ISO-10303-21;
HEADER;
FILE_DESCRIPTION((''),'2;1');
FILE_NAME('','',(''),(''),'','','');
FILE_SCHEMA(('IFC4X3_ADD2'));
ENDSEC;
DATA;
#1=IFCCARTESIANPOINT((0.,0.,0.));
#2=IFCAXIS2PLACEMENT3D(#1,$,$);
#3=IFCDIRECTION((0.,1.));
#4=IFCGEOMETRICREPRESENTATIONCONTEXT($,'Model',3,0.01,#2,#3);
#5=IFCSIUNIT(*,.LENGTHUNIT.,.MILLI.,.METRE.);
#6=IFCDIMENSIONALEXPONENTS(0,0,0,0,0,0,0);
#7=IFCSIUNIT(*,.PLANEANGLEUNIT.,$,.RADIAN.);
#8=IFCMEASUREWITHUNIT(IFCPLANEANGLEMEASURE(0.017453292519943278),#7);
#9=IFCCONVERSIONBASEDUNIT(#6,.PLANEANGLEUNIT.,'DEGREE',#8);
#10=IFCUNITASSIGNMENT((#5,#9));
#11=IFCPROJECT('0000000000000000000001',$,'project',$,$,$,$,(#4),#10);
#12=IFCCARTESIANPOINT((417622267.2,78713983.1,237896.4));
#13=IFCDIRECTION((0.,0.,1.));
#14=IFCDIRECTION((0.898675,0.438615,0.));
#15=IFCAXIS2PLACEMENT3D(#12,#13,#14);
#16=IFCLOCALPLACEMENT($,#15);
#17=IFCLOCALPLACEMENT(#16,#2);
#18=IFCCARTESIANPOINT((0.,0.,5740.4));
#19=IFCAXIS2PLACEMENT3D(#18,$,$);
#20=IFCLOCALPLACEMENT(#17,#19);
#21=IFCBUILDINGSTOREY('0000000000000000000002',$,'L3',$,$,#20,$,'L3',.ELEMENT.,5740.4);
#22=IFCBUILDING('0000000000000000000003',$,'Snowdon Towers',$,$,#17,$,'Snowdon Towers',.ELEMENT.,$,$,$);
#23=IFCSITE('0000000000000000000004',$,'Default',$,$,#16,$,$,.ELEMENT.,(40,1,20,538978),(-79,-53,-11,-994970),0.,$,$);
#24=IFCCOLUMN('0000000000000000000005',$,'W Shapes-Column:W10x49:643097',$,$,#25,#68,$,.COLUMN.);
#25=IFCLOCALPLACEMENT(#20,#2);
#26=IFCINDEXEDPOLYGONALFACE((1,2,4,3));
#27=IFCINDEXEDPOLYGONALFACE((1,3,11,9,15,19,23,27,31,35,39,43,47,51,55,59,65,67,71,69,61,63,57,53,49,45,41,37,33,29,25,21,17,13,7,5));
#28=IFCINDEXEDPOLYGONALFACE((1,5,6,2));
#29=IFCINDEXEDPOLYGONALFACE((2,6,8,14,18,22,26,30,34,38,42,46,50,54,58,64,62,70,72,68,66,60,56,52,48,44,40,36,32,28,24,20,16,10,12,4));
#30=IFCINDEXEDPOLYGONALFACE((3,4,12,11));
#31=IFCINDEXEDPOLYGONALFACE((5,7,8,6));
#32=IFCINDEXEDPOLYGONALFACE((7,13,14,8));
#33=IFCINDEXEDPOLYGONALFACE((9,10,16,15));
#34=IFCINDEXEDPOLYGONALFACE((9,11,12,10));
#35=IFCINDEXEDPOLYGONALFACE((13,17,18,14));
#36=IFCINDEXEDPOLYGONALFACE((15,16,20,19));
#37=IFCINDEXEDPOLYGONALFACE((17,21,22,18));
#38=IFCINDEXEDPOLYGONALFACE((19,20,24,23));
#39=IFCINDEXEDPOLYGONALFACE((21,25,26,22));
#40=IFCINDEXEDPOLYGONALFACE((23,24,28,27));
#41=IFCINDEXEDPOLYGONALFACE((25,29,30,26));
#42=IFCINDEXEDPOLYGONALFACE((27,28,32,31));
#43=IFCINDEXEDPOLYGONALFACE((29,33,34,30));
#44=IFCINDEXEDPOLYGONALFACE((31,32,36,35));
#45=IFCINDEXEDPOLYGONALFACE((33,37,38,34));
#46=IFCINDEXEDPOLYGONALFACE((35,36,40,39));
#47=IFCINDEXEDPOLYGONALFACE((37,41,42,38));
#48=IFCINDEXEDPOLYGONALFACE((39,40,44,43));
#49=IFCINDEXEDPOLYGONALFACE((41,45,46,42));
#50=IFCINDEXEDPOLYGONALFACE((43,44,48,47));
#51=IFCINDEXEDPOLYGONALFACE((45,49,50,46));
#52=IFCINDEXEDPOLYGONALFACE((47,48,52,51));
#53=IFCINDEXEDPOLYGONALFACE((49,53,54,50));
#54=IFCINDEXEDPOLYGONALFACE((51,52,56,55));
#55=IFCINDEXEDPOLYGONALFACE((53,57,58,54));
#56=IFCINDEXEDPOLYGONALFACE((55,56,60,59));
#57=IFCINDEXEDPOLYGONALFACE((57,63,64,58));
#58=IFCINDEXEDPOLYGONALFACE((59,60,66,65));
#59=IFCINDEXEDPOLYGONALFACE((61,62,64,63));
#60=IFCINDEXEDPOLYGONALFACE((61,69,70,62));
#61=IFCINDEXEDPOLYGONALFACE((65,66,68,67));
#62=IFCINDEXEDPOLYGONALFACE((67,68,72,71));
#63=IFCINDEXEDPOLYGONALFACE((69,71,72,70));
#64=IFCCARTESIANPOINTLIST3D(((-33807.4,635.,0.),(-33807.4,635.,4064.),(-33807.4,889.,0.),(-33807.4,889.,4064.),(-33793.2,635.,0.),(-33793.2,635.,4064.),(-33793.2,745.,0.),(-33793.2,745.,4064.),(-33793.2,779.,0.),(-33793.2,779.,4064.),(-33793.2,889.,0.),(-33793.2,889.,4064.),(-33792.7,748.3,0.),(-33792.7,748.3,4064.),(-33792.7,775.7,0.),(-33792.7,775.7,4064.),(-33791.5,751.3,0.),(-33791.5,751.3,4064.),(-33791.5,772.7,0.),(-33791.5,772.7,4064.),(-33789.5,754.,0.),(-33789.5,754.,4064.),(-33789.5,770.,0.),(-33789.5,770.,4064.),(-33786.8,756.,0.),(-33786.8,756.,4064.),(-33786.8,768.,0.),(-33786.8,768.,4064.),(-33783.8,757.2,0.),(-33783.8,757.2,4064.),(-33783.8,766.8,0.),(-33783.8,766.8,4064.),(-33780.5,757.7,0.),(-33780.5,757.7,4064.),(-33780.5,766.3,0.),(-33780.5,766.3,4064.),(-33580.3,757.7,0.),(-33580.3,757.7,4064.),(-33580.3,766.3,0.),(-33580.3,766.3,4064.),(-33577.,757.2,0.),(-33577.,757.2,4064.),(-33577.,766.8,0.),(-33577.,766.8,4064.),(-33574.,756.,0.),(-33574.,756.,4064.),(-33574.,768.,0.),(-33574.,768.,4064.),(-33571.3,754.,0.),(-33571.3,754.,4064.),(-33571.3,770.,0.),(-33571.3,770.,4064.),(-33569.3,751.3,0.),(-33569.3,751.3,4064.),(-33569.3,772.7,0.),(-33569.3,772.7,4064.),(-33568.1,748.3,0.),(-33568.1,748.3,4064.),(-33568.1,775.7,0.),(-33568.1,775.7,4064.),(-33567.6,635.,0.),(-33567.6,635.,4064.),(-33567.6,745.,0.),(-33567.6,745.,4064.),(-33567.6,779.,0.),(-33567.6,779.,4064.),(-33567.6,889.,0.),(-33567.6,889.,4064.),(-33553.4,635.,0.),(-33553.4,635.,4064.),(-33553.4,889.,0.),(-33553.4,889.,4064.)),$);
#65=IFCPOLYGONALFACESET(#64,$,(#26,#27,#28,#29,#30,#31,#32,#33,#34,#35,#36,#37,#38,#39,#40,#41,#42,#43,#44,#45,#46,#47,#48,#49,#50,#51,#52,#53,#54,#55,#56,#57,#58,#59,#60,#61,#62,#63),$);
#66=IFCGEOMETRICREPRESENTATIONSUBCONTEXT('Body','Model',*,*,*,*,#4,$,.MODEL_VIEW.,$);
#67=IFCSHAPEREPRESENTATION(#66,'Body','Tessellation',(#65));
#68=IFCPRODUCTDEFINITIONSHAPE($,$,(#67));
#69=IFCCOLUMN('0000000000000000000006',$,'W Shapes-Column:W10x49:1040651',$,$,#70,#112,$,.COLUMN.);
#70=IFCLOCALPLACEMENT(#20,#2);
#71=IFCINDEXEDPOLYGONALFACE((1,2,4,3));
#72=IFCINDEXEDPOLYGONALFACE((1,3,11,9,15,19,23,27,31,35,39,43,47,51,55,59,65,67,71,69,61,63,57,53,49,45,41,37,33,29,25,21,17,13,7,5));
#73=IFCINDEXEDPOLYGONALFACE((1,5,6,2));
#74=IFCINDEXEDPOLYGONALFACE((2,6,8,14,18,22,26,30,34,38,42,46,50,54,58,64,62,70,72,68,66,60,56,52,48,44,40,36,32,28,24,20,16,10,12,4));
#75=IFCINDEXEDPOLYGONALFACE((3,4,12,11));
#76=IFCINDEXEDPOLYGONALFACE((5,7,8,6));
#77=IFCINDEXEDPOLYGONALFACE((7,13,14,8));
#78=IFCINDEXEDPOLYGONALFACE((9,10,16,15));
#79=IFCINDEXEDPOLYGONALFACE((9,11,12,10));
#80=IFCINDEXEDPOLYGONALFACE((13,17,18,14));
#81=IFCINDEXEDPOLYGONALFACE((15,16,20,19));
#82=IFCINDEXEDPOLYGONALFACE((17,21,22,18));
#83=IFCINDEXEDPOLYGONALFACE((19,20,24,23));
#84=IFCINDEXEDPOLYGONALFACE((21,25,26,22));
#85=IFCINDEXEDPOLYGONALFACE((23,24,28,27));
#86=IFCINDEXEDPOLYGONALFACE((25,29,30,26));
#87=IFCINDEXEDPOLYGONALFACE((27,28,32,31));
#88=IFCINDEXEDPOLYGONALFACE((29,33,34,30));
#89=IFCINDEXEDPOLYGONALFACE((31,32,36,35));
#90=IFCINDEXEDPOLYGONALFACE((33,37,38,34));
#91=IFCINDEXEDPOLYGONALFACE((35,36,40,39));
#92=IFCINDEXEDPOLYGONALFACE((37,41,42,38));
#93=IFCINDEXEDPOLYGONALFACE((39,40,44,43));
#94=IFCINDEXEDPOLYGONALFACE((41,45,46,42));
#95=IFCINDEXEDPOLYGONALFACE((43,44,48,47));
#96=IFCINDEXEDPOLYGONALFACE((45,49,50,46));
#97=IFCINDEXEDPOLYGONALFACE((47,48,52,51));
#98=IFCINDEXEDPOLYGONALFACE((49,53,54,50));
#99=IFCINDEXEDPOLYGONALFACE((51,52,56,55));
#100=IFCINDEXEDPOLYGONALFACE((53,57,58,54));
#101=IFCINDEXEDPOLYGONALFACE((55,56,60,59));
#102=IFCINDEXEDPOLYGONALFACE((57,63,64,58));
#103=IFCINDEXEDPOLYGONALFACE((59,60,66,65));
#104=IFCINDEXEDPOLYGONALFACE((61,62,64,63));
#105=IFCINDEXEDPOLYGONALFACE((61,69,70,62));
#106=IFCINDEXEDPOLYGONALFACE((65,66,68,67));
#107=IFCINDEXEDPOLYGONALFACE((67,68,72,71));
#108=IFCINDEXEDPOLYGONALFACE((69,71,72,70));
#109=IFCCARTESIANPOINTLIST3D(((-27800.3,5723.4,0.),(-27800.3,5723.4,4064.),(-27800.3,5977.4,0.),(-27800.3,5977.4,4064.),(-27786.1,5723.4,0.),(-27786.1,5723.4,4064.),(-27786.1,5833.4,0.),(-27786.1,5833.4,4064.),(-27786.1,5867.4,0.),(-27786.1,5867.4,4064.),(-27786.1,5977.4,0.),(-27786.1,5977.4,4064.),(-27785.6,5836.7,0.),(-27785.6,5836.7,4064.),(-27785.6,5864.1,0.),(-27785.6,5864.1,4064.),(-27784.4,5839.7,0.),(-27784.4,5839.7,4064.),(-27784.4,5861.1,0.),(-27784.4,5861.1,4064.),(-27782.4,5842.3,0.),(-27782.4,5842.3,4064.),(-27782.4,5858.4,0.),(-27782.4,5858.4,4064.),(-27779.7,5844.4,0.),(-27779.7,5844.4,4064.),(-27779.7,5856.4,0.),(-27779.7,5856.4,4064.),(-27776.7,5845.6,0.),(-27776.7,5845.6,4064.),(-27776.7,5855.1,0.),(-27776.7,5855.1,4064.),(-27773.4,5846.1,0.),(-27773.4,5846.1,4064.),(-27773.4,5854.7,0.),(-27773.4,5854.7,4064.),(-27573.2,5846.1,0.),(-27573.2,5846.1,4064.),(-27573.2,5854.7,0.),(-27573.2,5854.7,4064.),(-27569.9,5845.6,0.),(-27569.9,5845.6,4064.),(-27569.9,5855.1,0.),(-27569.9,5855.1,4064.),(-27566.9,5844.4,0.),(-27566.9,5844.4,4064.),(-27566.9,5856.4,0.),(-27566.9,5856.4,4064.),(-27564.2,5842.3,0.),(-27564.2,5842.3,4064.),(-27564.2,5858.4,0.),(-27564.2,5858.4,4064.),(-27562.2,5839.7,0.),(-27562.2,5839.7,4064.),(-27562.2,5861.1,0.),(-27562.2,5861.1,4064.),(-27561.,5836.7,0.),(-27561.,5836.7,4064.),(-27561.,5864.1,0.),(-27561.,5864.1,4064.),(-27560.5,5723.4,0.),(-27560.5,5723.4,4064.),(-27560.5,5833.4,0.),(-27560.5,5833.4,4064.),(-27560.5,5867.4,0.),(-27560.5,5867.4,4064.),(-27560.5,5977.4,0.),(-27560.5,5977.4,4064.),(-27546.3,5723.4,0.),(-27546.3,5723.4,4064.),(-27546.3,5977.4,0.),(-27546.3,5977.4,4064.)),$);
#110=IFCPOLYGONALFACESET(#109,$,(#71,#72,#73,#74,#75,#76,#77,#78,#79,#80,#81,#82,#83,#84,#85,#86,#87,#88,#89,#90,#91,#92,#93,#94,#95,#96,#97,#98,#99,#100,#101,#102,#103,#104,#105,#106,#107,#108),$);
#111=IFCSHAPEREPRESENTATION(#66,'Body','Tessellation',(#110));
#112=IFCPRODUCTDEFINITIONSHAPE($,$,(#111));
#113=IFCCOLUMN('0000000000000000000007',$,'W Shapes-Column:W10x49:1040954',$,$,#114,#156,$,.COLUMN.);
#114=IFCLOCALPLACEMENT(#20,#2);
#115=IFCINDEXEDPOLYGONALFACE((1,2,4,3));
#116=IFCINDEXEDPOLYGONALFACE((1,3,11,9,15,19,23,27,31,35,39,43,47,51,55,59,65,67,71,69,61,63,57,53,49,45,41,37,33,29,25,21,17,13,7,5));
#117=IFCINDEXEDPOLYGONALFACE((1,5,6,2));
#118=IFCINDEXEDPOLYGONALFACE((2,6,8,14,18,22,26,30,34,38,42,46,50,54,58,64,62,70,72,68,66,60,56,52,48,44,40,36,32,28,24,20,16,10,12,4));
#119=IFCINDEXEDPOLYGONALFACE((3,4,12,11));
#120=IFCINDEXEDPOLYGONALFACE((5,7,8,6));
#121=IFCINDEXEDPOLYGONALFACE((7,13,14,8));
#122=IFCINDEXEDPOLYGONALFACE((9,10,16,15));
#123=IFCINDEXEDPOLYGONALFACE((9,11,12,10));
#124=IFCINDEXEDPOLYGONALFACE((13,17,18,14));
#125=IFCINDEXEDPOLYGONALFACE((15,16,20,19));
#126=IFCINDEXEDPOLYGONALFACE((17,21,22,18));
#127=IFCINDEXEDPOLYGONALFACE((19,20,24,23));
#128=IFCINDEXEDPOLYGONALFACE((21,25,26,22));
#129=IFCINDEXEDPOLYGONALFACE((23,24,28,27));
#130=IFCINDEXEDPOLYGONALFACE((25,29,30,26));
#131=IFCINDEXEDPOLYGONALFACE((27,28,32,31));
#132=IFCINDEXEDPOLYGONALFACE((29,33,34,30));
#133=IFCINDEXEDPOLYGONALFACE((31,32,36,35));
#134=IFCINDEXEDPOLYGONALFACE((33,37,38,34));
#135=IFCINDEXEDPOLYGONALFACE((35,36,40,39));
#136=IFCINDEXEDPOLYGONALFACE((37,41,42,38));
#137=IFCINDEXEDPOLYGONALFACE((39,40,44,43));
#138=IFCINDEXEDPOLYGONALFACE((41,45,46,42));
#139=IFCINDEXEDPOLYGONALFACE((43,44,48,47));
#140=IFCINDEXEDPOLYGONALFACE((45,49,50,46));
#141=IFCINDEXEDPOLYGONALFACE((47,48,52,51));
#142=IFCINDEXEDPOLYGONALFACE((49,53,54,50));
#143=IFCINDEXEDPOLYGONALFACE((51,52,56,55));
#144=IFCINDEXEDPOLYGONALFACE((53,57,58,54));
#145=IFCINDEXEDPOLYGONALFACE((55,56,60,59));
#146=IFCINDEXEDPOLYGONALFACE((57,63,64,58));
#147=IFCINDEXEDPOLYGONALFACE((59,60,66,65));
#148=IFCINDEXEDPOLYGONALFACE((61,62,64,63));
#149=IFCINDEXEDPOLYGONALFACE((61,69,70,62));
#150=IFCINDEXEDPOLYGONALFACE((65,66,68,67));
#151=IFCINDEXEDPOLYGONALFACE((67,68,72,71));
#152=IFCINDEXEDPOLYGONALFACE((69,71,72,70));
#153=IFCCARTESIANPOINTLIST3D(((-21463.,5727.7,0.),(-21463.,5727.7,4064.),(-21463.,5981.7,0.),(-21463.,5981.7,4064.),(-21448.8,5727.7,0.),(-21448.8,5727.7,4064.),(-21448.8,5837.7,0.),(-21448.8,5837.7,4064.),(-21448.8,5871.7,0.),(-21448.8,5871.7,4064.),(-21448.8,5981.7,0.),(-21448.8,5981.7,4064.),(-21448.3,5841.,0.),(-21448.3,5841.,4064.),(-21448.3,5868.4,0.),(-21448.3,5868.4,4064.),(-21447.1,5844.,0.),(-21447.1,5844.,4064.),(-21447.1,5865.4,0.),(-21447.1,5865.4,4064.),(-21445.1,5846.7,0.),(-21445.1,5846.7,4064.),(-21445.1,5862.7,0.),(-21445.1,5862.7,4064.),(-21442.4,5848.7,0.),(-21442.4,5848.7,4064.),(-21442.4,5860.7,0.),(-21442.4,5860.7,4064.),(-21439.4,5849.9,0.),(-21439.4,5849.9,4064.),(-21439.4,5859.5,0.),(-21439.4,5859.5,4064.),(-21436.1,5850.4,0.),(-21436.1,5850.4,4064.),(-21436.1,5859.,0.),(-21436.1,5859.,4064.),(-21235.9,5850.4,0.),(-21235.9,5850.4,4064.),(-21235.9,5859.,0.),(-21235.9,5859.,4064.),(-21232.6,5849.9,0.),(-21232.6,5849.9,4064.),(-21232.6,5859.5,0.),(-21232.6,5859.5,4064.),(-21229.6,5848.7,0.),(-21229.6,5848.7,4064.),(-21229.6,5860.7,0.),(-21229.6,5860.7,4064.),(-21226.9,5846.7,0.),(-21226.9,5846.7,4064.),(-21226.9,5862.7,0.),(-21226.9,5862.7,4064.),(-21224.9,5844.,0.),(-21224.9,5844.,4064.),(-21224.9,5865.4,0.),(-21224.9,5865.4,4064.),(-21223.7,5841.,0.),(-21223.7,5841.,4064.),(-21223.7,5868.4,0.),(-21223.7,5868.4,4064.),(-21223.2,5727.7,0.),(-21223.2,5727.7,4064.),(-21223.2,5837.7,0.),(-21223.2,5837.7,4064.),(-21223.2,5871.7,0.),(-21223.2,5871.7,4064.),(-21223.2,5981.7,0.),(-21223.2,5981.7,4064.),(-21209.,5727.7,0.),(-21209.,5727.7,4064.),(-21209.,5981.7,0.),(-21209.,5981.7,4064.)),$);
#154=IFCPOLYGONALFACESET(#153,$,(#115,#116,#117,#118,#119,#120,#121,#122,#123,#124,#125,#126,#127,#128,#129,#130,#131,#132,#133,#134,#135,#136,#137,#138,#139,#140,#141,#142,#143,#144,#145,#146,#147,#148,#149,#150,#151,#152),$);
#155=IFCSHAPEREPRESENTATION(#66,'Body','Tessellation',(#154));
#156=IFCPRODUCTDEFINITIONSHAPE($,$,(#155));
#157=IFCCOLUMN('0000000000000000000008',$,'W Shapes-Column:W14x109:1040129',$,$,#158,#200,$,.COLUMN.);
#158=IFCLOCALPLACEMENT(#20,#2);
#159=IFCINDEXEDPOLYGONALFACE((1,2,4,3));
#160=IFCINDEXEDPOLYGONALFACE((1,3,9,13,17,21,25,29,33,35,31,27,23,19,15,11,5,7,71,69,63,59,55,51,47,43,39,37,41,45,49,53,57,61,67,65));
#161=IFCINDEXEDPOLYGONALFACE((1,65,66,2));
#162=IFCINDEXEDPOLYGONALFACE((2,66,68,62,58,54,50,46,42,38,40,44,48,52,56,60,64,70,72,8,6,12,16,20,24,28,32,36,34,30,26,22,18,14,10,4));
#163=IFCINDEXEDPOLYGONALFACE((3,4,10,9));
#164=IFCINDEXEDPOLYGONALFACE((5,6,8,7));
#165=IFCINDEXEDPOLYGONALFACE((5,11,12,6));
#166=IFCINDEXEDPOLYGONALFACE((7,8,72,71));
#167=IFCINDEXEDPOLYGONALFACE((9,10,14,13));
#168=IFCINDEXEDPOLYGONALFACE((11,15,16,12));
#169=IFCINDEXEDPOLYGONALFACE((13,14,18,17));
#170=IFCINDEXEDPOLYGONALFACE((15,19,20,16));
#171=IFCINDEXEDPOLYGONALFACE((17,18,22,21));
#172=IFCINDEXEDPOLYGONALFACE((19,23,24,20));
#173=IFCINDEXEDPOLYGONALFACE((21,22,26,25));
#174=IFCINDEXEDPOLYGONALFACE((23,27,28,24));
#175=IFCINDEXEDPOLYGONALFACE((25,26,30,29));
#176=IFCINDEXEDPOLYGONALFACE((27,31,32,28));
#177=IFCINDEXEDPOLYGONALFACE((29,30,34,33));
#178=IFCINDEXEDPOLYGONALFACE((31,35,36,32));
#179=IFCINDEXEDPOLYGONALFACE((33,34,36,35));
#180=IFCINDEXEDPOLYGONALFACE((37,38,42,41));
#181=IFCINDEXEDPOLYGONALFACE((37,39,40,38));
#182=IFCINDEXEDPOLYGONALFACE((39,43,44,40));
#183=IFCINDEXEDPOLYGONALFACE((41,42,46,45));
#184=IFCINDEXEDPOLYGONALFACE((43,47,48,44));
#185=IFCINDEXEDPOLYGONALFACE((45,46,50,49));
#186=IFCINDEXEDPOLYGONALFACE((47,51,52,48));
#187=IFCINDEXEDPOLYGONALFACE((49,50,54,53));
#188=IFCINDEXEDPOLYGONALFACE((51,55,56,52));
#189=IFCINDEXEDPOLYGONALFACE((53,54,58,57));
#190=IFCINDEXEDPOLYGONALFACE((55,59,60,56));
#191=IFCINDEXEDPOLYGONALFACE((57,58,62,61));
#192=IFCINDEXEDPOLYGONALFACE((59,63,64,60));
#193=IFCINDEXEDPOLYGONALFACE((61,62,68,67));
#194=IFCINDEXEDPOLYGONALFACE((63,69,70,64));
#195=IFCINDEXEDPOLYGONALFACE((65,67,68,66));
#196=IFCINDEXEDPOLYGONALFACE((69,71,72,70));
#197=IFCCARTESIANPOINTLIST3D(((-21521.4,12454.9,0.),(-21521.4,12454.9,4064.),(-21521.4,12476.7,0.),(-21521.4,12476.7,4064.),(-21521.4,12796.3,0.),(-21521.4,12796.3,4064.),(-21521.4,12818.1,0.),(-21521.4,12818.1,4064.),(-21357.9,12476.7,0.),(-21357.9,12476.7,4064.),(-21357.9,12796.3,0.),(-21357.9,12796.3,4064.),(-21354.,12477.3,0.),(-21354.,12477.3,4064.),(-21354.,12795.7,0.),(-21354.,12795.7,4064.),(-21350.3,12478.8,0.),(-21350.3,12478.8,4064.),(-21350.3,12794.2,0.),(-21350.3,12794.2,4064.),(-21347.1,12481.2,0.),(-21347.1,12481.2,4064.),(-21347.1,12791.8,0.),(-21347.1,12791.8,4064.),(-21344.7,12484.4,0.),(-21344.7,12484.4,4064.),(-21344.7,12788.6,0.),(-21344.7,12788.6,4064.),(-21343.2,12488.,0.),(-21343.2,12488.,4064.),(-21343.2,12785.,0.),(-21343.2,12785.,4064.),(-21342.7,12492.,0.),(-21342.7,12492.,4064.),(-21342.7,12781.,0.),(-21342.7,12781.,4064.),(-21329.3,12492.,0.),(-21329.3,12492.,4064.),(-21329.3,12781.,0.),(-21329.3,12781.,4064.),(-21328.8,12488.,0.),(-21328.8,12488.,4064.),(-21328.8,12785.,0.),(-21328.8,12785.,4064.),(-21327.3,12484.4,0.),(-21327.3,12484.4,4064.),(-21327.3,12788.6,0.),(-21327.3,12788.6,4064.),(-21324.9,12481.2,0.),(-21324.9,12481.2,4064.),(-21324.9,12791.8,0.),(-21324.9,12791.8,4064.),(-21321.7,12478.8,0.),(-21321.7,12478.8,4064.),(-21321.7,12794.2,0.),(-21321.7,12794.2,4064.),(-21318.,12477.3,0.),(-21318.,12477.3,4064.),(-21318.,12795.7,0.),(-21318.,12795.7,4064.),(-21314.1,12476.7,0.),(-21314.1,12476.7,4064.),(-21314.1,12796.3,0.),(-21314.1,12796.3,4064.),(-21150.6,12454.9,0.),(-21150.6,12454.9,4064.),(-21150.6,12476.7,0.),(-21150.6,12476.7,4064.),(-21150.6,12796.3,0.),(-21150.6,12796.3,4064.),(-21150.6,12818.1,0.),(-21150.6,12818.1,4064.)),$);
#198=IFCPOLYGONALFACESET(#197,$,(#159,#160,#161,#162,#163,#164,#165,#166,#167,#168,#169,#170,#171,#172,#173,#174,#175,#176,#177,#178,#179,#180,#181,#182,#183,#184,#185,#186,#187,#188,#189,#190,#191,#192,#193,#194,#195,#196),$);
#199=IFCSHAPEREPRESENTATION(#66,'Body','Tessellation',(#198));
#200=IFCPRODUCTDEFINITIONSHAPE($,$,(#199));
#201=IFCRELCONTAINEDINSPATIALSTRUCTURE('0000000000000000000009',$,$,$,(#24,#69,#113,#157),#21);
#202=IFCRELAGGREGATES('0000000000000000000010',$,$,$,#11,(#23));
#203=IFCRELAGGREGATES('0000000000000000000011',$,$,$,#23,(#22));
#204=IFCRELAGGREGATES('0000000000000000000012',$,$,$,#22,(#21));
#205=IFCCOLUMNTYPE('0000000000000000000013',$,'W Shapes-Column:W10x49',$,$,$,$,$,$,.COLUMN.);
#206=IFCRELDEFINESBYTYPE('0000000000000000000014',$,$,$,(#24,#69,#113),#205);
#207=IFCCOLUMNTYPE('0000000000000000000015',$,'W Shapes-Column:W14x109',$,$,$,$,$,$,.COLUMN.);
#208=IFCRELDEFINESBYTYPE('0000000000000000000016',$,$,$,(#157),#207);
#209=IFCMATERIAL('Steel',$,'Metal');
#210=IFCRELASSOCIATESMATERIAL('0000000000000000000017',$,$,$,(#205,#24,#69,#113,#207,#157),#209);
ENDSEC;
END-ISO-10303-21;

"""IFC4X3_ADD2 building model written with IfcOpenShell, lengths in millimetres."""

from ifc_helpers import new_model, entity, si_unit, converted_unit, direction, frame, frame_2d, origin, place, context, subcontext, project, spatial, i_section, extrude, source, transform, mapped, material, material_profile, profile_set, profile_usage, type_object, type_shapes, element, save


model = new_model("IFC4X3_ADD2")

# Units and contexts
model_context = context("Model", 3, precision=0.01, world=origin(), true_north=direction((0.0, 1.0)))
body_context = subcontext(model_context, "Body", "Model", "MODEL_VIEW")
ifc_project = project(units=[si_unit("LENGTHUNIT", "METRE", prefix="MILLI"), converted_unit("PLANEANGLEUNIT", "DEGREE", entity("IfcPlaneAngleMeasure", 0.017453292519943278), si_unit("PLANEANGLEUNIT", "RADIAN"), dimensions=[0, 0, 0, 0, 0, 0, 0])], contexts=[model_context])

# Site, building, storey
site_placement = place(None, frame((417622267.2, 78713983.1, 237896.4), z_axis=(0.0, 0.0, 1.0), x_axis=(0.898675, 0.438615, 0.0)))
site = spatial("IfcSite", under=ifc_project, at=site_placement, Name="Default", CompositionType="ELEMENT", RefLatitude=(40, 1, 20, 538978), RefLongitude=(-79, -53, -11, -994970), RefElevation=0.0)
building_placement = place(site_placement, origin())
building = spatial("IfcBuilding", under=site, at=building_placement, Name="Snowdon Towers", LongName="Snowdon Towers", CompositionType="ELEMENT")
storey_placement = place(building_placement, frame((0.0, 0.0, 5740.4)))
storey = spatial("IfcBuildingStorey", under=building, at=storey_placement, Name="L3", LongName="L3", CompositionType="ELEMENT", Elevation=5740.4)

# Columns
ifc_material_1 = material(Name="Steel", Category="Metal")
ifc_material_profile_1 = material_profile(ifc_material_1, i_section(OverallWidth=254.0, OverallDepth=254.0, WebThickness=8.6, FlangeThickness=14.2, FilletRadius=12.7, at=frame_2d((0.0, 0.0), x_axis=(1.0, 0.0))), Name="W10x49")
ifc_profile_set_1 = profile_set([ifc_material_profile_1], Name="W10x49")
ifc_profile_usage_1 = profile_usage(ifc_profile_set_1)
column_type_1 = type_object("IfcColumnType", Name="W Shapes-Column:W10x49", PredefinedType="COLUMN", material=ifc_profile_set_1)
shared_shape_1 = source(origin(), body_context, "Body", "SweptSolid", [
    extrude(i_section(OverallWidth=254.0, OverallDepth=254.0, WebThickness=8.6, FlangeThickness=14.2, FilletRadius=12.7, at=frame_2d((0.0, 0.0), x_axis=(1.0, 0.0))), frame((0.0, 0.0, 5740.4), z_axis=(0.0, 0.0, 1.0), x_axis=(-1.0, 0.0, 0.0)), (0.0, 0.0, 1.0), 4064.0),
])
type_shapes(column_type_1, [shared_shape_1])
for number, where, z_axis, x_axis, name in (
    (1, (-33680.4, 762.0, -5740.4), (0.0, 0.0, 1.0), (0.0, 1.0, 0.0), "W Shapes-Column:W10x49:643097"),
    (2, (-27673.3, 5850.4, -5740.4), (0.0, 0.0, 1.0), (0.0, 1.0, 0.0), "W Shapes-Column:W10x49:1040651"),
    (3, (-21336.0, 5854.7, -5740.4), (0.0, 0.0, 1.0), (0.0, 1.0, 0.0), "W Shapes-Column:W10x49:1040954"),
):
    element("IfcColumn", number, at=place(storey_placement, frame(where, z_axis=z_axis, x_axis=x_axis)), inside=storey, type_object=column_type_1, material=ifc_profile_usage_1, Name=name, PredefinedType="COLUMN", context=body_context, shape_type="MappedRepresentation", body=[
        mapped(shared_shape_1, transform((0.0, 0.0, 0.0), scale=1.0)),
    ])
ifc_material_profile_2 = material_profile(ifc_material_1, i_section(OverallWidth=370.8, OverallDepth=363.2, WebThickness=13.3, FlangeThickness=21.8, FilletRadius=15.2, at=frame_2d((0.0, 0.0), x_axis=(1.0, 0.0))), Name="W14x109")
ifc_profile_set_2 = profile_set([ifc_material_profile_2], Name="W14x109")
ifc_profile_usage_2 = profile_usage(ifc_profile_set_2)
column_type_2 = type_object("IfcColumnType", Name="W Shapes-Column:W14x109", PredefinedType="COLUMN", material=ifc_profile_set_2)
shared_shape_2 = source(origin(), body_context, "Body", "SweptSolid", [
    extrude(i_section(OverallWidth=370.8, OverallDepth=363.2, WebThickness=13.3, FlangeThickness=21.8, FilletRadius=15.2, at=frame_2d((0.0, 0.0), x_axis=(1.0, 0.0))), frame((0.0, 0.0, 5740.4), z_axis=(0.0, 0.0, 1.0), x_axis=(-1.0, 0.0, 0.0)), (0.0, 0.0, 1.0), 4064.0),
])
type_shapes(column_type_2, [shared_shape_2])
for number, where, z_axis, x_axis, name in (
    (4, (-21336.0, 12636.5, -5740.4), (0.0, 0.0, 1.0), (-1.0, 0.0, 0.0), "W Shapes-Column:W14x109:1040129"),
):
    element("IfcColumn", number, at=place(storey_placement, frame(where, z_axis=z_axis, x_axis=x_axis)), inside=storey, type_object=column_type_2, material=ifc_profile_usage_2, Name=name, PredefinedType="COLUMN", context=body_context, shape_type="MappedRepresentation", body=[
        mapped(shared_shape_2, transform((0.0, 0.0, 0.0), scale=1.0)),
    ])

save(model, "model.ifc")
